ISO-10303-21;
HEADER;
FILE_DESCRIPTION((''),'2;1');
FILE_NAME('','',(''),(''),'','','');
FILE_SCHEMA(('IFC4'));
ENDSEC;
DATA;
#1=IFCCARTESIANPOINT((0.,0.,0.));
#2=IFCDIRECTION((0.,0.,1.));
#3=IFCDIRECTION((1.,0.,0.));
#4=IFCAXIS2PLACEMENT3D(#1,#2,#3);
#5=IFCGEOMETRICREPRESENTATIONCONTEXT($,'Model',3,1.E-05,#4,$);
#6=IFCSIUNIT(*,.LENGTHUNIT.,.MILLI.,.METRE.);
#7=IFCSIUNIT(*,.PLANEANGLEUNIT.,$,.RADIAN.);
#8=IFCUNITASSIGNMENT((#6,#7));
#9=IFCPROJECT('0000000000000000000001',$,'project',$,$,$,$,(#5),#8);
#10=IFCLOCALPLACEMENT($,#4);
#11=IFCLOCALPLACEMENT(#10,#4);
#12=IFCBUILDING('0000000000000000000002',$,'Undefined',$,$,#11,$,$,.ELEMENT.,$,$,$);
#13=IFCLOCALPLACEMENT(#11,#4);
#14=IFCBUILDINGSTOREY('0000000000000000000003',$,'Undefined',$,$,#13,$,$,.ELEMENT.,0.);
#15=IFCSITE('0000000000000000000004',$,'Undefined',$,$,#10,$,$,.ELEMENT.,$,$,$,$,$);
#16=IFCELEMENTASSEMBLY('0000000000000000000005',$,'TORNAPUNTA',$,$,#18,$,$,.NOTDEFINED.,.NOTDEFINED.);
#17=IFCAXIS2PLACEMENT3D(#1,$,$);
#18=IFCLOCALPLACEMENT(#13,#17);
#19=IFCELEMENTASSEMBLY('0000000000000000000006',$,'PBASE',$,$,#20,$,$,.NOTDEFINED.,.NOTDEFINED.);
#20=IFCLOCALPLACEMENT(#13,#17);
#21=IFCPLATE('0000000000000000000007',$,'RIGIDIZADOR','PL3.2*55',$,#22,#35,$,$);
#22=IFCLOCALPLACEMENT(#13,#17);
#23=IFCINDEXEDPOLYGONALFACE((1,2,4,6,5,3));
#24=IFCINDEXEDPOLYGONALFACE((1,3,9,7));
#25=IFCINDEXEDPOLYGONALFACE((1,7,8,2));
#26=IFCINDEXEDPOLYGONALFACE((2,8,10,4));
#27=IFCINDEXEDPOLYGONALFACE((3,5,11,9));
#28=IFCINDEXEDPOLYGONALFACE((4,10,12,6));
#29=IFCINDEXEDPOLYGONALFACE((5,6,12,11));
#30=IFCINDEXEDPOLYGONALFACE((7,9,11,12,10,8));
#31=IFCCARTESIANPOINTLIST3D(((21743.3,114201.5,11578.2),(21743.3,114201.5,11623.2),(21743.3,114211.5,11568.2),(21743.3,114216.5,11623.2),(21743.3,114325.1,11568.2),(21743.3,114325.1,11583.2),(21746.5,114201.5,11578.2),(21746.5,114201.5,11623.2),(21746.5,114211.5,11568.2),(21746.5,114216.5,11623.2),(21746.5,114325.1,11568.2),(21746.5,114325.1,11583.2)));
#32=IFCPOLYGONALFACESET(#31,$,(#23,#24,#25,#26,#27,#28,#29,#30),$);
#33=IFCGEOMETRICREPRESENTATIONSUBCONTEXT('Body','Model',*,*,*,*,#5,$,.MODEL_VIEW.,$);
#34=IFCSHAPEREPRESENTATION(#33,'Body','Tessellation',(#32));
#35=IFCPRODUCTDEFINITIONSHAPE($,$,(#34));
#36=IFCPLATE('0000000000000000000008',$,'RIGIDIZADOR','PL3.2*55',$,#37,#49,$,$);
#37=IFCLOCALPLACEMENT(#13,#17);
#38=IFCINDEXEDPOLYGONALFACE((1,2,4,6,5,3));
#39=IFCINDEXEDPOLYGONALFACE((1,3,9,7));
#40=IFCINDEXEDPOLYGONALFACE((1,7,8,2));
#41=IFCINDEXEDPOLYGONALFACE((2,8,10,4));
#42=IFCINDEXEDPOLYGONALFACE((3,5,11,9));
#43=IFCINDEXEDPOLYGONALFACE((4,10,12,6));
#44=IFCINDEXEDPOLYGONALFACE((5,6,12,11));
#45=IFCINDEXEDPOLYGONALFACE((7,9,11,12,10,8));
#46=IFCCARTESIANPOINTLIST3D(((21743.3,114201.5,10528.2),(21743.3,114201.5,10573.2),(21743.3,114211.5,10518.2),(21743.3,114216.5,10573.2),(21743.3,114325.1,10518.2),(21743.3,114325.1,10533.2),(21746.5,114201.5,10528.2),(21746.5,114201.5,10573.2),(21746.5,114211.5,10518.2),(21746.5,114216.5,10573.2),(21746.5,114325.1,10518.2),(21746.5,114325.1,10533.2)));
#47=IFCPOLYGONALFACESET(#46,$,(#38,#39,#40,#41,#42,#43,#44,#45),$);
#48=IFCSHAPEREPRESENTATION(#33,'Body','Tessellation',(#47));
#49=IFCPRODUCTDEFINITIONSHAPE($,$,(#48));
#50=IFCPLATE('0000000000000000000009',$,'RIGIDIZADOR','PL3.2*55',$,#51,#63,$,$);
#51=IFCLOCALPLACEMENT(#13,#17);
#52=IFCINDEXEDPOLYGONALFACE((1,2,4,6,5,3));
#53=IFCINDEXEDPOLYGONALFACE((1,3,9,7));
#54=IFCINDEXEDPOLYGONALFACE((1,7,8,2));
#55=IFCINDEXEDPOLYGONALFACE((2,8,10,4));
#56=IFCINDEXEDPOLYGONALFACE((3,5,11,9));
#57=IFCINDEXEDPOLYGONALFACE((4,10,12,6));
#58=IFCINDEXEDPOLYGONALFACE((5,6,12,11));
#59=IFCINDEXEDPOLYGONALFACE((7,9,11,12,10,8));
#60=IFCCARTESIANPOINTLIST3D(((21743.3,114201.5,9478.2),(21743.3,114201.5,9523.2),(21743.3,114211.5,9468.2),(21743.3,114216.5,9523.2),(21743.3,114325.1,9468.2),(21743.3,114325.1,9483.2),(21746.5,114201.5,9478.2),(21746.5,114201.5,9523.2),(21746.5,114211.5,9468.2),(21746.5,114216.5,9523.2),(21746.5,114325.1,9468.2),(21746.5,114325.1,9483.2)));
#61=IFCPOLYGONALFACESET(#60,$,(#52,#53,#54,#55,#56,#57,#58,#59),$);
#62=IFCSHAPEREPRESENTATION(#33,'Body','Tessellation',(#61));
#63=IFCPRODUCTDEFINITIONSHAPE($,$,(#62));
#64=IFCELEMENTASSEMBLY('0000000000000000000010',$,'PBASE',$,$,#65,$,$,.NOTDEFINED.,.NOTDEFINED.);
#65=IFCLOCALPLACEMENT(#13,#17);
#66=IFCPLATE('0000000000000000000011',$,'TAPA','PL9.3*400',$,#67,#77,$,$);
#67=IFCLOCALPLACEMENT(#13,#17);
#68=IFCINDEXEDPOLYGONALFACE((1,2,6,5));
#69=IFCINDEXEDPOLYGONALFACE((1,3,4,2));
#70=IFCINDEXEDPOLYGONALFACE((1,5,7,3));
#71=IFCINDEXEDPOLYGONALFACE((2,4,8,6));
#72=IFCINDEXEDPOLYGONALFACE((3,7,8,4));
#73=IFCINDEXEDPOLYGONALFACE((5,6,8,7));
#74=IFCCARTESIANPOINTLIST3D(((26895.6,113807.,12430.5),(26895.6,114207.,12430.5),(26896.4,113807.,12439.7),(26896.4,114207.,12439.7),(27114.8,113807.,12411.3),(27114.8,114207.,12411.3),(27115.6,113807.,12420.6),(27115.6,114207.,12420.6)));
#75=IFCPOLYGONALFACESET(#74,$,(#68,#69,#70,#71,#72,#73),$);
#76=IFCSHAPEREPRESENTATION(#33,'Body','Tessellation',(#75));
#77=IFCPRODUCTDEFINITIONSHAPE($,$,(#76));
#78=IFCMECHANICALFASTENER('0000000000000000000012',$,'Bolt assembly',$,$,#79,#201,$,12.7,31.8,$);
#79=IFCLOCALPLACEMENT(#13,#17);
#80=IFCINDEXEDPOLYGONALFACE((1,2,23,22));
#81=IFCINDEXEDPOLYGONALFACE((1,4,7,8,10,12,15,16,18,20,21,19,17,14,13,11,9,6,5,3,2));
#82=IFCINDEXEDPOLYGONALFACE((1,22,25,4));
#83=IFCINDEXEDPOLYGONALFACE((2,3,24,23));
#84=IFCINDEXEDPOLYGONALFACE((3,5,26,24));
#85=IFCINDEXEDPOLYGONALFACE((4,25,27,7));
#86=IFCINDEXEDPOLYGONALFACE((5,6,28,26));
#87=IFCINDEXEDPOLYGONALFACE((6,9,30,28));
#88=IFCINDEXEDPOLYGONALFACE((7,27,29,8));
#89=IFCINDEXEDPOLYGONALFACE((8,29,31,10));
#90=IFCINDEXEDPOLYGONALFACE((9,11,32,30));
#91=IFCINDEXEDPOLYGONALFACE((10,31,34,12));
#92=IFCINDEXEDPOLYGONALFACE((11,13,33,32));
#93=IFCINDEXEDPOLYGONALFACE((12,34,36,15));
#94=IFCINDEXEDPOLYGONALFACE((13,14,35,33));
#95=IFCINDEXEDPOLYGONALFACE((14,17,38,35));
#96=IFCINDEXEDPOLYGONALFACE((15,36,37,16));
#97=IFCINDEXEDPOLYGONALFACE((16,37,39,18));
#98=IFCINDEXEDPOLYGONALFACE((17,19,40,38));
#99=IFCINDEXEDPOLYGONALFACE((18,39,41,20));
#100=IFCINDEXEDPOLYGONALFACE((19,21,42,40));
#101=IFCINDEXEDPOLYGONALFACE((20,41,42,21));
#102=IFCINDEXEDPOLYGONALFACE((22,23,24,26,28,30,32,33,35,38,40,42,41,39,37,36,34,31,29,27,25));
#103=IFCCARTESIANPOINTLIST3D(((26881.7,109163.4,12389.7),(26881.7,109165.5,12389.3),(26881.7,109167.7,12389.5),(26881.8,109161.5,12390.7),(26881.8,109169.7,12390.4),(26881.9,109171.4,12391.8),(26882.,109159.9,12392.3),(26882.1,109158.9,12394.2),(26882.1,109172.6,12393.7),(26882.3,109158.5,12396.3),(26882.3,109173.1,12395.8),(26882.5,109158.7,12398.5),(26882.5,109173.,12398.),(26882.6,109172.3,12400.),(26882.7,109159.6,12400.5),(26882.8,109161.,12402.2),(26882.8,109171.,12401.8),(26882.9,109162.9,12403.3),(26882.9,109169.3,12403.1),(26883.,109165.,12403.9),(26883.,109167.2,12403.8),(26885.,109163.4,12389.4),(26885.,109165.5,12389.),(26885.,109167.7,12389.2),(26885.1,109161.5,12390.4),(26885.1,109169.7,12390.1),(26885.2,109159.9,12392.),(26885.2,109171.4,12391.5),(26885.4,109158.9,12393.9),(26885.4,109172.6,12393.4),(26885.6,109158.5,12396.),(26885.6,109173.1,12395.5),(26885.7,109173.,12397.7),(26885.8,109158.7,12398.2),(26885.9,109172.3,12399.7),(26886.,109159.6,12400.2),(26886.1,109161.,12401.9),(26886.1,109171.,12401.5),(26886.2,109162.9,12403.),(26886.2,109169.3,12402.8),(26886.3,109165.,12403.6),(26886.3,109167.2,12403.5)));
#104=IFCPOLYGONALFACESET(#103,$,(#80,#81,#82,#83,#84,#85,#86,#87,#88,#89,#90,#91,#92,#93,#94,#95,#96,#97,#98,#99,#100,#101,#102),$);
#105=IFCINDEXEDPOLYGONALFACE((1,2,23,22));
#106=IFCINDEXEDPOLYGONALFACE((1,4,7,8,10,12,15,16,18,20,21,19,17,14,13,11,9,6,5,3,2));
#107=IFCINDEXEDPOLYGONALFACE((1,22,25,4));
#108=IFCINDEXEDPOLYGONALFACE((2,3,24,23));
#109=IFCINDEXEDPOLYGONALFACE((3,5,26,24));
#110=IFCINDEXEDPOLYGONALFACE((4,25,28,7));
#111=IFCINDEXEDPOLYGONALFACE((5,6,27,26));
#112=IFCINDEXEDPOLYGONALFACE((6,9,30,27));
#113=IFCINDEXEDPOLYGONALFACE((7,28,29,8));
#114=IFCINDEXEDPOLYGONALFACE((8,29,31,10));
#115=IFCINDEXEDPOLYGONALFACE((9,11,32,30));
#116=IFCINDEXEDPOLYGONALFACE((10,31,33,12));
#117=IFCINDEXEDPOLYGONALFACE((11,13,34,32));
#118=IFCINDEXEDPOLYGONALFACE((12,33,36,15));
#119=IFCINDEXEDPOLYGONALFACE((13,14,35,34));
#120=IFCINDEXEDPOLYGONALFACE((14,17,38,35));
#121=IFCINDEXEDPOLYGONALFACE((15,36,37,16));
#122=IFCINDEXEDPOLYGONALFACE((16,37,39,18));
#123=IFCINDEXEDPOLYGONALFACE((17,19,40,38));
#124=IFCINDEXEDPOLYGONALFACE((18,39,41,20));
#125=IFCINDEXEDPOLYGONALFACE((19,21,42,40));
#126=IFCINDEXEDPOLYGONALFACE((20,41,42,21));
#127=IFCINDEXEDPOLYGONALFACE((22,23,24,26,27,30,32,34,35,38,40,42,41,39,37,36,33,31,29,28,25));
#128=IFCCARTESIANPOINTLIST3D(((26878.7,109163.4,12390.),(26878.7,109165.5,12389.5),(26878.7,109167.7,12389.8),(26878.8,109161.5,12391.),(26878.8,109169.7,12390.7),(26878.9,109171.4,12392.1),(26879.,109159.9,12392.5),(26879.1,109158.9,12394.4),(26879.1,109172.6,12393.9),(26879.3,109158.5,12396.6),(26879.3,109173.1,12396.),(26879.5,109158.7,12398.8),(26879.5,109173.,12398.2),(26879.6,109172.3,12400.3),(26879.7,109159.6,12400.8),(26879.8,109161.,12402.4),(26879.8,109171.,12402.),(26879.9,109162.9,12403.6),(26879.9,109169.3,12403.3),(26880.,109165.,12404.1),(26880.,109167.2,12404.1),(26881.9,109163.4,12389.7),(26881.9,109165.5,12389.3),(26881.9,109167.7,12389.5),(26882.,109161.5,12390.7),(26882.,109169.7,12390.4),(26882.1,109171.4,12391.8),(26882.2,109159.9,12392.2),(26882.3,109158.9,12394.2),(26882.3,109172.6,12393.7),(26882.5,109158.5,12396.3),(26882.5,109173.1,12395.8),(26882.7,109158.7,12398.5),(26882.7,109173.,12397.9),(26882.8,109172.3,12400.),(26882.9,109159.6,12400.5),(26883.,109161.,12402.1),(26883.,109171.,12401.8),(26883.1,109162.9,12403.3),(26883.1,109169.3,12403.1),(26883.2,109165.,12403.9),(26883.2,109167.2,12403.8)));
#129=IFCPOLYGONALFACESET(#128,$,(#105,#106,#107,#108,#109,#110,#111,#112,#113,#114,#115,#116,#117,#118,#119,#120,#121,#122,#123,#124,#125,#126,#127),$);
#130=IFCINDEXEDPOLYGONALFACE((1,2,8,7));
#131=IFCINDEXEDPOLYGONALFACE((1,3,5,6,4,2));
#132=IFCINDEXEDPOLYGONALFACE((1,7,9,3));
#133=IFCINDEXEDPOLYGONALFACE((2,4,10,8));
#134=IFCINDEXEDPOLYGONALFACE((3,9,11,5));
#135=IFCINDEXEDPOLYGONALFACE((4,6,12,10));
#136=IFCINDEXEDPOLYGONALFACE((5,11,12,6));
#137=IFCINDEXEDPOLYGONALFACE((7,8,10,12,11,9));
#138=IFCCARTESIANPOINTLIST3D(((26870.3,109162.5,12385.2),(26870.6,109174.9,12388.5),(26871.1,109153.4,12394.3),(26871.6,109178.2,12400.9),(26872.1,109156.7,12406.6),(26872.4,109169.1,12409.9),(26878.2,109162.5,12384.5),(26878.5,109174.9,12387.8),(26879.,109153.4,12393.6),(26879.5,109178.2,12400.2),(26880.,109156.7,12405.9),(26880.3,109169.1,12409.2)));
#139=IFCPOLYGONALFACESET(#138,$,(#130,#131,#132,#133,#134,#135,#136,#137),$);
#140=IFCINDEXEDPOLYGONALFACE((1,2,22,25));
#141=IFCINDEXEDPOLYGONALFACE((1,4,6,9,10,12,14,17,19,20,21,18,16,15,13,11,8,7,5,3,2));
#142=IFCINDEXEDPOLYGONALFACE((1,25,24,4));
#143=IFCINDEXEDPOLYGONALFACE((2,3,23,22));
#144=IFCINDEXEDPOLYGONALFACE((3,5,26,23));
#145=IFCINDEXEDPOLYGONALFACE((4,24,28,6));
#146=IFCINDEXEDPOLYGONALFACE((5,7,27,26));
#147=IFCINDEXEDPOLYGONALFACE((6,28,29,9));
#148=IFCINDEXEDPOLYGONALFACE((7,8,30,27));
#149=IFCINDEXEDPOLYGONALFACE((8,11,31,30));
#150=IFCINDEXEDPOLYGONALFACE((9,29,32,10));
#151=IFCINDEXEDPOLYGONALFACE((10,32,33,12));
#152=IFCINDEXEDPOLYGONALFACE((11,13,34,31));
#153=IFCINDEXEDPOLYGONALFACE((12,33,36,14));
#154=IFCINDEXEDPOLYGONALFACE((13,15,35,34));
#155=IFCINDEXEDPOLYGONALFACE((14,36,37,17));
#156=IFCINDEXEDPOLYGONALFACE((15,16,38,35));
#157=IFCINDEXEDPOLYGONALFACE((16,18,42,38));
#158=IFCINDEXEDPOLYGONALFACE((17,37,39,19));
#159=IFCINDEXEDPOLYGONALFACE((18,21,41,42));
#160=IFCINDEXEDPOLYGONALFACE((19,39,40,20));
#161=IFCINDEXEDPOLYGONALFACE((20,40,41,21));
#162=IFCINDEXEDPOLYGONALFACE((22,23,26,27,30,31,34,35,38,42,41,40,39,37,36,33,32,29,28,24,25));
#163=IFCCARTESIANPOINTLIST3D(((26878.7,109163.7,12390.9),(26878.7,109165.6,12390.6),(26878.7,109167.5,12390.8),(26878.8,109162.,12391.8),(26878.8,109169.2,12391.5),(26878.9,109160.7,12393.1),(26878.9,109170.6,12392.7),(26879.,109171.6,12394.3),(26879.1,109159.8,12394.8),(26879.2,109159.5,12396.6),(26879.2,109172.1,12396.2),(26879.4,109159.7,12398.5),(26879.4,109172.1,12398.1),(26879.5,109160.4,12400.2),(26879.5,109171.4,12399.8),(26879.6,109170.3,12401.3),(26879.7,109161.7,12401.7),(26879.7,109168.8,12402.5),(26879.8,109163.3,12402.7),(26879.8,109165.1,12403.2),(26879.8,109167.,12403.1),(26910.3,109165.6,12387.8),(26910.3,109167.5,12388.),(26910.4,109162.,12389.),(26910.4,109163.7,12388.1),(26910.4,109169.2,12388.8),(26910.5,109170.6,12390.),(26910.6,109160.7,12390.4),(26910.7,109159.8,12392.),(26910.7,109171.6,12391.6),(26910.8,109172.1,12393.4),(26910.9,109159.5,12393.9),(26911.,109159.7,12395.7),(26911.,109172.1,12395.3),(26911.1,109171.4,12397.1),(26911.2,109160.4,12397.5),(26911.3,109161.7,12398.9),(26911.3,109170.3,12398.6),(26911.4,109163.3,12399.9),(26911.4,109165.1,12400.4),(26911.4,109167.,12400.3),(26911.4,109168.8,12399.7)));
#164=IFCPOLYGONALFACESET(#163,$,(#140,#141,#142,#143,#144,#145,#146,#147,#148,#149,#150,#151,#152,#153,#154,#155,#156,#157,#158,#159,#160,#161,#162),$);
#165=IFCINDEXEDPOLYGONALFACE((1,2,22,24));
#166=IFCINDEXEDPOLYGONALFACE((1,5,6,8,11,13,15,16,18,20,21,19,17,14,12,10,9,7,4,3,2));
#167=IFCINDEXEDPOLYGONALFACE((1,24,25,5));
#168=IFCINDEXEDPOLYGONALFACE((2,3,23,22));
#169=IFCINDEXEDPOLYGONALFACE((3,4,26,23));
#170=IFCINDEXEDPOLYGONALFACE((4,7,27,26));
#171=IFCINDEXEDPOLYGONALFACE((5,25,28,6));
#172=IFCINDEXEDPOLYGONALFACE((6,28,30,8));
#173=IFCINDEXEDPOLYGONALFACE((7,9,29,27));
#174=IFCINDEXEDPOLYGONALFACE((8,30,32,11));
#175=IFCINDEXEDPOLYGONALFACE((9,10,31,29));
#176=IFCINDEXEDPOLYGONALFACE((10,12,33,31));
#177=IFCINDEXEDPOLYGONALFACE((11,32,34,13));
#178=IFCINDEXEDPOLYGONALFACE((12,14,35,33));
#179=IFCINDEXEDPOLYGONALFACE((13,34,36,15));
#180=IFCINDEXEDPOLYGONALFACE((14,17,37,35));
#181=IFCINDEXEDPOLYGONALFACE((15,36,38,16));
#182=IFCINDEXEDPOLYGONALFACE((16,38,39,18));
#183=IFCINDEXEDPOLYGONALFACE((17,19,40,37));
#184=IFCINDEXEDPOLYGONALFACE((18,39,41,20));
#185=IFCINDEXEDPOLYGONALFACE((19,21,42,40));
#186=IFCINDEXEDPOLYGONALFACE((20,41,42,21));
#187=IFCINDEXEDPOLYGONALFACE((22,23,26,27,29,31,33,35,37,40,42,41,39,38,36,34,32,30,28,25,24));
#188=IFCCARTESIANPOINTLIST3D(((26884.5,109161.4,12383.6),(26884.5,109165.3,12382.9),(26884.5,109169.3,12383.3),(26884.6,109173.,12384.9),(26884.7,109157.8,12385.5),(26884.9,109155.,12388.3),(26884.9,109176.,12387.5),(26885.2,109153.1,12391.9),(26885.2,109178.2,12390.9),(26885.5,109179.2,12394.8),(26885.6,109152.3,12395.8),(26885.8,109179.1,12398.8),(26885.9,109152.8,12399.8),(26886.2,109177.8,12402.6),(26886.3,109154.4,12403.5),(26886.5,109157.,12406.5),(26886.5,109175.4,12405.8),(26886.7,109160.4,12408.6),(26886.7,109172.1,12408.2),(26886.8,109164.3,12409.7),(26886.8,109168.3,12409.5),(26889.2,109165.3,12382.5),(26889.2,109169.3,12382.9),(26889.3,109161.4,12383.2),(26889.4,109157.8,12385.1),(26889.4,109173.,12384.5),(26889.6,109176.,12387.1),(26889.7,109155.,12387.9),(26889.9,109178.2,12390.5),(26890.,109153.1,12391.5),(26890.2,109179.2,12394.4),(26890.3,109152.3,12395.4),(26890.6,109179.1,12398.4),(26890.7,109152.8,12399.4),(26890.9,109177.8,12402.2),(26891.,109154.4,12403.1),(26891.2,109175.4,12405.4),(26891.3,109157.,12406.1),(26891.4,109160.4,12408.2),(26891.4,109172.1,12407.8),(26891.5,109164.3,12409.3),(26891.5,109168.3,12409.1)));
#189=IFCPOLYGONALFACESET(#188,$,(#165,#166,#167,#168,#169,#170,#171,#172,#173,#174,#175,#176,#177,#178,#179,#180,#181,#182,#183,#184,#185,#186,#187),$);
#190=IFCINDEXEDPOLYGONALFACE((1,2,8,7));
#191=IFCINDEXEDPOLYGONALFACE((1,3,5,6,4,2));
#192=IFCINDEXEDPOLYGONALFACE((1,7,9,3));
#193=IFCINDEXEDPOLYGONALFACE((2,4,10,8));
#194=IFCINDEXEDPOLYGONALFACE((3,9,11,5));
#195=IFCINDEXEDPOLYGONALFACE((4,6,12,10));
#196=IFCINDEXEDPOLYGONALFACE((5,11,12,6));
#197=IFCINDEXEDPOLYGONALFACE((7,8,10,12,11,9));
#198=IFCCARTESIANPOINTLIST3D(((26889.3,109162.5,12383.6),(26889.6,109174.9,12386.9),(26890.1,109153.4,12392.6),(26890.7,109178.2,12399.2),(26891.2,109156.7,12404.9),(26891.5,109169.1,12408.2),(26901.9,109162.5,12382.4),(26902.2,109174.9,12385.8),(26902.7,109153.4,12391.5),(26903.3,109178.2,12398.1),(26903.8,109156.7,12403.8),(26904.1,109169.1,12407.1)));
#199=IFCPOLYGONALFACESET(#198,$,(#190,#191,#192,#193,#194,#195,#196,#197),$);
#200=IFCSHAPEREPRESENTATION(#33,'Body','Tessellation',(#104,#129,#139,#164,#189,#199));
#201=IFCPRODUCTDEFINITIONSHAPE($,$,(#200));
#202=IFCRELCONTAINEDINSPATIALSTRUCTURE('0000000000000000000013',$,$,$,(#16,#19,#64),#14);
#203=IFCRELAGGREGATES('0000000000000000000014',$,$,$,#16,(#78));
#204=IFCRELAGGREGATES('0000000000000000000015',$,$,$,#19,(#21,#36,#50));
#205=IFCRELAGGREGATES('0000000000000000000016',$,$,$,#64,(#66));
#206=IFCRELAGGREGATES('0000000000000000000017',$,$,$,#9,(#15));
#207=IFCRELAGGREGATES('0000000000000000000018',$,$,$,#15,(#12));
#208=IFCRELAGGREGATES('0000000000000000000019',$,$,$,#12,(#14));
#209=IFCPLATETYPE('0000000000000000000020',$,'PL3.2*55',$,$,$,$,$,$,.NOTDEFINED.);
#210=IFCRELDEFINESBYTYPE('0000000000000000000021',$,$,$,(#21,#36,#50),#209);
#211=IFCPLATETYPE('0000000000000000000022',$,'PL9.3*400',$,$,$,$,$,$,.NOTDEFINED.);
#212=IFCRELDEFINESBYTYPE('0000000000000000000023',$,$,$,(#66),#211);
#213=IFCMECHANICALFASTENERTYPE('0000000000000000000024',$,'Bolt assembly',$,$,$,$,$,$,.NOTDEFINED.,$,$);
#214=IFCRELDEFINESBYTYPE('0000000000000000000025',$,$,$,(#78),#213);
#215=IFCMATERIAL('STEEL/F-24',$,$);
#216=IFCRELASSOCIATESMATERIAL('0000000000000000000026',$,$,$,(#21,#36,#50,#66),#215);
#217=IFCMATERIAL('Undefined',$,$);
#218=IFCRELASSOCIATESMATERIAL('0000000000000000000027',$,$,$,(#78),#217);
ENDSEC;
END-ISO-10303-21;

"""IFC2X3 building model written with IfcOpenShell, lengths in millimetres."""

from ifc_helpers import new_model, si_unit, frame, origin_with_axes, origin_2d_with_axis, place, context, subcontext, project, spatial, polyline, circle, outline, extrude, source, transform, mapped, material, type_object, element, aggregate, save


model = new_model("IFC2X3")

# Units and contexts
model_context = context("Model", 3, precision=1e-05, world=origin_with_axes())
body_context = subcontext(model_context, "Body", "Model", "MODEL_VIEW")
ifc_project = project(units=[si_unit("LENGTHUNIT", "METRE", prefix="MILLI"), si_unit("PLANEANGLEUNIT", "RADIAN")], contexts=[model_context])

# Site, building, storey
site_placement = place(None, origin_with_axes())
site = spatial("IfcSite", under=ifc_project, at=site_placement, Name="Undefined", CompositionType="ELEMENT")
building_placement = place(site_placement, origin_with_axes())
building = spatial("IfcBuilding", under=site, at=building_placement, Name="Undefined", CompositionType="ELEMENT")
storey_placement = place(building_placement, origin_with_axes())
storey = spatial("IfcBuildingStorey", under=building, at=storey_placement, Name="Undefined", CompositionType="ELEMENT", Elevation=0.0)

# Element assembly
assembly_1_placement = place(storey_placement, origin_with_axes())
assembly_1 = element("IfcElementAssembly", 1, at=assembly_1_placement, inside=storey, Name="TORNAPUNTA", AssemblyPlace="NOTDEFINED", PredefinedType="NOTDEFINED")
ifc_material_1 = material(Name="STEEL/F-24")

# Element assembly
assembly_2_placement = place(storey_placement, origin_with_axes())
assembly_2 = element("IfcElementAssembly", 2, at=assembly_2_placement, inside=storey, Name="PBASE", AssemblyPlace="NOTDEFINED", PredefinedType="NOTDEFINED")

# Plates
plate_type_1 = type_object("IfcPlateType", Name="PL3.2*55", PredefinedType="NOTDEFINED")
plate_1_placement = place(assembly_2_placement, frame((21744.9, 114325.1, 11568.2), z_axis=(-1.0, 0.0, 0.0), x_axis=(0.0, -1.0, 0.0)))
plate_1 = element("IfcPlate", 3, at=plate_1_placement, type_object=plate_type_1, material=ifc_material_1, Name="RIGIDIZADOR", Description="PL3.2*55", context=body_context, shape_type="SweptSolid", body=[
    extrude(outline(polyline([(0.0, 0.0), (113.7, 0.0), (123.7, 10.0), (123.7, 55.0), (108.7, 55.0), (0.0, 15.0), (0.0, 0.0)])), frame((0.0, 0.0, -1.6), z_axis=(0.0, 0.0, 1.0), x_axis=(1.0, 0.0, 0.0)), (0.0, 0.0, 1.0), 3.2),
])
plate_2_placement = place(assembly_2_placement, frame((21744.9, 114325.1, 10518.2), z_axis=(-1.0, 0.0, 0.0), x_axis=(0.0, -1.0, 0.0)))
plate_2 = element("IfcPlate", 4, at=plate_2_placement, type_object=plate_type_1, material=ifc_material_1, Name="RIGIDIZADOR", Description="PL3.2*55", context=body_context, shape_type="SweptSolid", body=[
    extrude(outline(polyline([(0.0, 0.0), (113.7, 0.0), (123.7, 10.0), (123.7, 55.0), (108.7, 55.0), (0.0, 15.0), (0.0, 0.0)])), frame((0.0, 0.0, -1.6), z_axis=(0.0, 0.0, 1.0), x_axis=(1.0, 0.0, 0.0)), (0.0, 0.0, 1.0), 3.2),
])
plate_3_placement = place(assembly_2_placement, frame((21744.9, 114325.1, 9468.2), z_axis=(-1.0, 0.0, 0.0), x_axis=(0.0, -1.0, 0.0)))
plate_3 = element("IfcPlate", 5, at=plate_3_placement, type_object=plate_type_1, material=ifc_material_1, Name="RIGIDIZADOR", Description="PL3.2*55", context=body_context, shape_type="SweptSolid", body=[
    extrude(outline(polyline([(0.0, 0.0), (113.7, 0.0), (123.7, 10.0), (123.7, 55.0), (108.7, 55.0), (0.0, 15.0), (0.0, 0.0)])), frame((0.0, 0.0, -1.6), z_axis=(0.0, 0.0, 1.0), x_axis=(1.0, 0.0, 0.0)), (0.0, 0.0, 1.0), 3.2),
])

# Element assembly, plate
assembly_3_placement = place(storey_placement, origin_with_axes())
assembly_3 = element("IfcElementAssembly", 6, at=assembly_3_placement, inside=storey, Name="PBASE", AssemblyPlace="NOTDEFINED", PredefinedType="NOTDEFINED")
plate_type_2 = type_object("IfcPlateType", Name="PL9.3*400", PredefinedType="NOTDEFINED")
plate_4_placement = place(assembly_3_placement, frame((26896.0, 114007.0, 12435.1), z_axis=(-0.087155, 0.0, -0.996195), x_axis=(0.996195, 0.0, -0.087155)))
plate_4 = element("IfcPlate", 7, at=plate_4_placement, type_object=plate_type_2, material=ifc_material_1, Name="TAPA", Description="PL9.3*400", context=body_context, shape_type="SweptSolid", body=[
    extrude(outline(polyline([(0.0, -200.0), (0.0, 200.0), (220.0, 200.0), (220.0, -200.0), (0.0, -200.0)])), frame((0.0, 0.0, -4.7), z_axis=(0.0, 0.0, 1.0), x_axis=(1.0, 0.0, 0.0)), (0.0, 0.0, 1.0), 9.3),
])

# Mechanical fastener
ifc_material_2 = material(Name="Undefined")
mechanical_fastener_type = type_object("IfcMechanicalFastenerType", Name="Bolt assembly")
shared_shape_1 = source(origin_with_axes(), body_context, "Body", "SweptSolid", [
    extrude(circle(Radius=7.3, at=origin_2d_with_axis()), frame((0.0, -0.1, 0.0), z_axis=(0.0, 1.0, 0.0), x_axis=(1.0, 0.0, 0.0)), (0.0, 0.0, 1.0), 3.3),
    extrude(circle(Radius=7.3, at=origin_2d_with_axis()), frame((0.0, -3.1, 0.0), z_axis=(0.0, 1.0, 0.0), x_axis=(1.0, 0.0, 0.0)), (0.0, 0.0, 1.0), 3.2),
    extrude(outline(polyline([(11.1, -6.4), (11.1, 6.4), (0.0, 12.8), (-11.1, 6.4), (-11.1, -6.4), (0.0, -12.8), (11.1, -6.4)])), frame((0.0, -11.1, 0.0), z_axis=(0.0, 1.0, 0.0), x_axis=(1.0, 0.0, 0.0)), (0.0, 0.0, 1.0), 7.9),
    extrude(circle(Radius=6.3, at=origin_2d_with_axis()), frame((0.0, -3.2, 0.0), z_axis=(0.0, 1.0, 0.0), x_axis=(1.0, 0.0, 0.0)), (0.0, 0.0, 1.0), 31.8),
    extrude(circle(Radius=13.5, at=origin_2d_with_axis()), frame((0.0, 3.2, 0.0), z_axis=(0.0, 1.0, 0.0), x_axis=(1.0, 0.0, 0.0)), (0.0, 0.0, 1.0), 4.8),
    extrude(outline(polyline([(11.1, -6.4), (11.1, 6.4), (0.0, 12.8), (-11.1, 6.4), (-11.1, -6.4), (0.0, -12.8), (11.1, -6.4)])), frame((0.0, 8.0, 0.0), z_axis=(0.0, 1.0, 0.0), x_axis=(1.0, 0.0, 0.0)), (0.0, 0.0, 1.0), 12.7),
])
mechanical_fastener_1_placement = place(assembly_1_placement, frame((26882.4, 109165.8, 12396.6), z_axis=(-0.061628, 0.707107, -0.704416), x_axis=(0.061628, 0.707107, 0.704416)))
mechanical_fastener_1 = element("IfcMechanicalFastener", 8, at=mechanical_fastener_1_placement, type_object=mechanical_fastener_type, material=ifc_material_2, Name="Bolt assembly", NominalDiameter=12.7, NominalLength=31.8, context=body_context, shape_type="MappedRepresentation", body=[
    mapped(shared_shape_1, transform((0.0, 0.0, 0.0))),
])
aggregate(assembly_1, [mechanical_fastener_1])

aggregate(assembly_2, [plate_1, plate_2, plate_3])
aggregate(assembly_3, [plate_4])

save(model, "model.ifc")
